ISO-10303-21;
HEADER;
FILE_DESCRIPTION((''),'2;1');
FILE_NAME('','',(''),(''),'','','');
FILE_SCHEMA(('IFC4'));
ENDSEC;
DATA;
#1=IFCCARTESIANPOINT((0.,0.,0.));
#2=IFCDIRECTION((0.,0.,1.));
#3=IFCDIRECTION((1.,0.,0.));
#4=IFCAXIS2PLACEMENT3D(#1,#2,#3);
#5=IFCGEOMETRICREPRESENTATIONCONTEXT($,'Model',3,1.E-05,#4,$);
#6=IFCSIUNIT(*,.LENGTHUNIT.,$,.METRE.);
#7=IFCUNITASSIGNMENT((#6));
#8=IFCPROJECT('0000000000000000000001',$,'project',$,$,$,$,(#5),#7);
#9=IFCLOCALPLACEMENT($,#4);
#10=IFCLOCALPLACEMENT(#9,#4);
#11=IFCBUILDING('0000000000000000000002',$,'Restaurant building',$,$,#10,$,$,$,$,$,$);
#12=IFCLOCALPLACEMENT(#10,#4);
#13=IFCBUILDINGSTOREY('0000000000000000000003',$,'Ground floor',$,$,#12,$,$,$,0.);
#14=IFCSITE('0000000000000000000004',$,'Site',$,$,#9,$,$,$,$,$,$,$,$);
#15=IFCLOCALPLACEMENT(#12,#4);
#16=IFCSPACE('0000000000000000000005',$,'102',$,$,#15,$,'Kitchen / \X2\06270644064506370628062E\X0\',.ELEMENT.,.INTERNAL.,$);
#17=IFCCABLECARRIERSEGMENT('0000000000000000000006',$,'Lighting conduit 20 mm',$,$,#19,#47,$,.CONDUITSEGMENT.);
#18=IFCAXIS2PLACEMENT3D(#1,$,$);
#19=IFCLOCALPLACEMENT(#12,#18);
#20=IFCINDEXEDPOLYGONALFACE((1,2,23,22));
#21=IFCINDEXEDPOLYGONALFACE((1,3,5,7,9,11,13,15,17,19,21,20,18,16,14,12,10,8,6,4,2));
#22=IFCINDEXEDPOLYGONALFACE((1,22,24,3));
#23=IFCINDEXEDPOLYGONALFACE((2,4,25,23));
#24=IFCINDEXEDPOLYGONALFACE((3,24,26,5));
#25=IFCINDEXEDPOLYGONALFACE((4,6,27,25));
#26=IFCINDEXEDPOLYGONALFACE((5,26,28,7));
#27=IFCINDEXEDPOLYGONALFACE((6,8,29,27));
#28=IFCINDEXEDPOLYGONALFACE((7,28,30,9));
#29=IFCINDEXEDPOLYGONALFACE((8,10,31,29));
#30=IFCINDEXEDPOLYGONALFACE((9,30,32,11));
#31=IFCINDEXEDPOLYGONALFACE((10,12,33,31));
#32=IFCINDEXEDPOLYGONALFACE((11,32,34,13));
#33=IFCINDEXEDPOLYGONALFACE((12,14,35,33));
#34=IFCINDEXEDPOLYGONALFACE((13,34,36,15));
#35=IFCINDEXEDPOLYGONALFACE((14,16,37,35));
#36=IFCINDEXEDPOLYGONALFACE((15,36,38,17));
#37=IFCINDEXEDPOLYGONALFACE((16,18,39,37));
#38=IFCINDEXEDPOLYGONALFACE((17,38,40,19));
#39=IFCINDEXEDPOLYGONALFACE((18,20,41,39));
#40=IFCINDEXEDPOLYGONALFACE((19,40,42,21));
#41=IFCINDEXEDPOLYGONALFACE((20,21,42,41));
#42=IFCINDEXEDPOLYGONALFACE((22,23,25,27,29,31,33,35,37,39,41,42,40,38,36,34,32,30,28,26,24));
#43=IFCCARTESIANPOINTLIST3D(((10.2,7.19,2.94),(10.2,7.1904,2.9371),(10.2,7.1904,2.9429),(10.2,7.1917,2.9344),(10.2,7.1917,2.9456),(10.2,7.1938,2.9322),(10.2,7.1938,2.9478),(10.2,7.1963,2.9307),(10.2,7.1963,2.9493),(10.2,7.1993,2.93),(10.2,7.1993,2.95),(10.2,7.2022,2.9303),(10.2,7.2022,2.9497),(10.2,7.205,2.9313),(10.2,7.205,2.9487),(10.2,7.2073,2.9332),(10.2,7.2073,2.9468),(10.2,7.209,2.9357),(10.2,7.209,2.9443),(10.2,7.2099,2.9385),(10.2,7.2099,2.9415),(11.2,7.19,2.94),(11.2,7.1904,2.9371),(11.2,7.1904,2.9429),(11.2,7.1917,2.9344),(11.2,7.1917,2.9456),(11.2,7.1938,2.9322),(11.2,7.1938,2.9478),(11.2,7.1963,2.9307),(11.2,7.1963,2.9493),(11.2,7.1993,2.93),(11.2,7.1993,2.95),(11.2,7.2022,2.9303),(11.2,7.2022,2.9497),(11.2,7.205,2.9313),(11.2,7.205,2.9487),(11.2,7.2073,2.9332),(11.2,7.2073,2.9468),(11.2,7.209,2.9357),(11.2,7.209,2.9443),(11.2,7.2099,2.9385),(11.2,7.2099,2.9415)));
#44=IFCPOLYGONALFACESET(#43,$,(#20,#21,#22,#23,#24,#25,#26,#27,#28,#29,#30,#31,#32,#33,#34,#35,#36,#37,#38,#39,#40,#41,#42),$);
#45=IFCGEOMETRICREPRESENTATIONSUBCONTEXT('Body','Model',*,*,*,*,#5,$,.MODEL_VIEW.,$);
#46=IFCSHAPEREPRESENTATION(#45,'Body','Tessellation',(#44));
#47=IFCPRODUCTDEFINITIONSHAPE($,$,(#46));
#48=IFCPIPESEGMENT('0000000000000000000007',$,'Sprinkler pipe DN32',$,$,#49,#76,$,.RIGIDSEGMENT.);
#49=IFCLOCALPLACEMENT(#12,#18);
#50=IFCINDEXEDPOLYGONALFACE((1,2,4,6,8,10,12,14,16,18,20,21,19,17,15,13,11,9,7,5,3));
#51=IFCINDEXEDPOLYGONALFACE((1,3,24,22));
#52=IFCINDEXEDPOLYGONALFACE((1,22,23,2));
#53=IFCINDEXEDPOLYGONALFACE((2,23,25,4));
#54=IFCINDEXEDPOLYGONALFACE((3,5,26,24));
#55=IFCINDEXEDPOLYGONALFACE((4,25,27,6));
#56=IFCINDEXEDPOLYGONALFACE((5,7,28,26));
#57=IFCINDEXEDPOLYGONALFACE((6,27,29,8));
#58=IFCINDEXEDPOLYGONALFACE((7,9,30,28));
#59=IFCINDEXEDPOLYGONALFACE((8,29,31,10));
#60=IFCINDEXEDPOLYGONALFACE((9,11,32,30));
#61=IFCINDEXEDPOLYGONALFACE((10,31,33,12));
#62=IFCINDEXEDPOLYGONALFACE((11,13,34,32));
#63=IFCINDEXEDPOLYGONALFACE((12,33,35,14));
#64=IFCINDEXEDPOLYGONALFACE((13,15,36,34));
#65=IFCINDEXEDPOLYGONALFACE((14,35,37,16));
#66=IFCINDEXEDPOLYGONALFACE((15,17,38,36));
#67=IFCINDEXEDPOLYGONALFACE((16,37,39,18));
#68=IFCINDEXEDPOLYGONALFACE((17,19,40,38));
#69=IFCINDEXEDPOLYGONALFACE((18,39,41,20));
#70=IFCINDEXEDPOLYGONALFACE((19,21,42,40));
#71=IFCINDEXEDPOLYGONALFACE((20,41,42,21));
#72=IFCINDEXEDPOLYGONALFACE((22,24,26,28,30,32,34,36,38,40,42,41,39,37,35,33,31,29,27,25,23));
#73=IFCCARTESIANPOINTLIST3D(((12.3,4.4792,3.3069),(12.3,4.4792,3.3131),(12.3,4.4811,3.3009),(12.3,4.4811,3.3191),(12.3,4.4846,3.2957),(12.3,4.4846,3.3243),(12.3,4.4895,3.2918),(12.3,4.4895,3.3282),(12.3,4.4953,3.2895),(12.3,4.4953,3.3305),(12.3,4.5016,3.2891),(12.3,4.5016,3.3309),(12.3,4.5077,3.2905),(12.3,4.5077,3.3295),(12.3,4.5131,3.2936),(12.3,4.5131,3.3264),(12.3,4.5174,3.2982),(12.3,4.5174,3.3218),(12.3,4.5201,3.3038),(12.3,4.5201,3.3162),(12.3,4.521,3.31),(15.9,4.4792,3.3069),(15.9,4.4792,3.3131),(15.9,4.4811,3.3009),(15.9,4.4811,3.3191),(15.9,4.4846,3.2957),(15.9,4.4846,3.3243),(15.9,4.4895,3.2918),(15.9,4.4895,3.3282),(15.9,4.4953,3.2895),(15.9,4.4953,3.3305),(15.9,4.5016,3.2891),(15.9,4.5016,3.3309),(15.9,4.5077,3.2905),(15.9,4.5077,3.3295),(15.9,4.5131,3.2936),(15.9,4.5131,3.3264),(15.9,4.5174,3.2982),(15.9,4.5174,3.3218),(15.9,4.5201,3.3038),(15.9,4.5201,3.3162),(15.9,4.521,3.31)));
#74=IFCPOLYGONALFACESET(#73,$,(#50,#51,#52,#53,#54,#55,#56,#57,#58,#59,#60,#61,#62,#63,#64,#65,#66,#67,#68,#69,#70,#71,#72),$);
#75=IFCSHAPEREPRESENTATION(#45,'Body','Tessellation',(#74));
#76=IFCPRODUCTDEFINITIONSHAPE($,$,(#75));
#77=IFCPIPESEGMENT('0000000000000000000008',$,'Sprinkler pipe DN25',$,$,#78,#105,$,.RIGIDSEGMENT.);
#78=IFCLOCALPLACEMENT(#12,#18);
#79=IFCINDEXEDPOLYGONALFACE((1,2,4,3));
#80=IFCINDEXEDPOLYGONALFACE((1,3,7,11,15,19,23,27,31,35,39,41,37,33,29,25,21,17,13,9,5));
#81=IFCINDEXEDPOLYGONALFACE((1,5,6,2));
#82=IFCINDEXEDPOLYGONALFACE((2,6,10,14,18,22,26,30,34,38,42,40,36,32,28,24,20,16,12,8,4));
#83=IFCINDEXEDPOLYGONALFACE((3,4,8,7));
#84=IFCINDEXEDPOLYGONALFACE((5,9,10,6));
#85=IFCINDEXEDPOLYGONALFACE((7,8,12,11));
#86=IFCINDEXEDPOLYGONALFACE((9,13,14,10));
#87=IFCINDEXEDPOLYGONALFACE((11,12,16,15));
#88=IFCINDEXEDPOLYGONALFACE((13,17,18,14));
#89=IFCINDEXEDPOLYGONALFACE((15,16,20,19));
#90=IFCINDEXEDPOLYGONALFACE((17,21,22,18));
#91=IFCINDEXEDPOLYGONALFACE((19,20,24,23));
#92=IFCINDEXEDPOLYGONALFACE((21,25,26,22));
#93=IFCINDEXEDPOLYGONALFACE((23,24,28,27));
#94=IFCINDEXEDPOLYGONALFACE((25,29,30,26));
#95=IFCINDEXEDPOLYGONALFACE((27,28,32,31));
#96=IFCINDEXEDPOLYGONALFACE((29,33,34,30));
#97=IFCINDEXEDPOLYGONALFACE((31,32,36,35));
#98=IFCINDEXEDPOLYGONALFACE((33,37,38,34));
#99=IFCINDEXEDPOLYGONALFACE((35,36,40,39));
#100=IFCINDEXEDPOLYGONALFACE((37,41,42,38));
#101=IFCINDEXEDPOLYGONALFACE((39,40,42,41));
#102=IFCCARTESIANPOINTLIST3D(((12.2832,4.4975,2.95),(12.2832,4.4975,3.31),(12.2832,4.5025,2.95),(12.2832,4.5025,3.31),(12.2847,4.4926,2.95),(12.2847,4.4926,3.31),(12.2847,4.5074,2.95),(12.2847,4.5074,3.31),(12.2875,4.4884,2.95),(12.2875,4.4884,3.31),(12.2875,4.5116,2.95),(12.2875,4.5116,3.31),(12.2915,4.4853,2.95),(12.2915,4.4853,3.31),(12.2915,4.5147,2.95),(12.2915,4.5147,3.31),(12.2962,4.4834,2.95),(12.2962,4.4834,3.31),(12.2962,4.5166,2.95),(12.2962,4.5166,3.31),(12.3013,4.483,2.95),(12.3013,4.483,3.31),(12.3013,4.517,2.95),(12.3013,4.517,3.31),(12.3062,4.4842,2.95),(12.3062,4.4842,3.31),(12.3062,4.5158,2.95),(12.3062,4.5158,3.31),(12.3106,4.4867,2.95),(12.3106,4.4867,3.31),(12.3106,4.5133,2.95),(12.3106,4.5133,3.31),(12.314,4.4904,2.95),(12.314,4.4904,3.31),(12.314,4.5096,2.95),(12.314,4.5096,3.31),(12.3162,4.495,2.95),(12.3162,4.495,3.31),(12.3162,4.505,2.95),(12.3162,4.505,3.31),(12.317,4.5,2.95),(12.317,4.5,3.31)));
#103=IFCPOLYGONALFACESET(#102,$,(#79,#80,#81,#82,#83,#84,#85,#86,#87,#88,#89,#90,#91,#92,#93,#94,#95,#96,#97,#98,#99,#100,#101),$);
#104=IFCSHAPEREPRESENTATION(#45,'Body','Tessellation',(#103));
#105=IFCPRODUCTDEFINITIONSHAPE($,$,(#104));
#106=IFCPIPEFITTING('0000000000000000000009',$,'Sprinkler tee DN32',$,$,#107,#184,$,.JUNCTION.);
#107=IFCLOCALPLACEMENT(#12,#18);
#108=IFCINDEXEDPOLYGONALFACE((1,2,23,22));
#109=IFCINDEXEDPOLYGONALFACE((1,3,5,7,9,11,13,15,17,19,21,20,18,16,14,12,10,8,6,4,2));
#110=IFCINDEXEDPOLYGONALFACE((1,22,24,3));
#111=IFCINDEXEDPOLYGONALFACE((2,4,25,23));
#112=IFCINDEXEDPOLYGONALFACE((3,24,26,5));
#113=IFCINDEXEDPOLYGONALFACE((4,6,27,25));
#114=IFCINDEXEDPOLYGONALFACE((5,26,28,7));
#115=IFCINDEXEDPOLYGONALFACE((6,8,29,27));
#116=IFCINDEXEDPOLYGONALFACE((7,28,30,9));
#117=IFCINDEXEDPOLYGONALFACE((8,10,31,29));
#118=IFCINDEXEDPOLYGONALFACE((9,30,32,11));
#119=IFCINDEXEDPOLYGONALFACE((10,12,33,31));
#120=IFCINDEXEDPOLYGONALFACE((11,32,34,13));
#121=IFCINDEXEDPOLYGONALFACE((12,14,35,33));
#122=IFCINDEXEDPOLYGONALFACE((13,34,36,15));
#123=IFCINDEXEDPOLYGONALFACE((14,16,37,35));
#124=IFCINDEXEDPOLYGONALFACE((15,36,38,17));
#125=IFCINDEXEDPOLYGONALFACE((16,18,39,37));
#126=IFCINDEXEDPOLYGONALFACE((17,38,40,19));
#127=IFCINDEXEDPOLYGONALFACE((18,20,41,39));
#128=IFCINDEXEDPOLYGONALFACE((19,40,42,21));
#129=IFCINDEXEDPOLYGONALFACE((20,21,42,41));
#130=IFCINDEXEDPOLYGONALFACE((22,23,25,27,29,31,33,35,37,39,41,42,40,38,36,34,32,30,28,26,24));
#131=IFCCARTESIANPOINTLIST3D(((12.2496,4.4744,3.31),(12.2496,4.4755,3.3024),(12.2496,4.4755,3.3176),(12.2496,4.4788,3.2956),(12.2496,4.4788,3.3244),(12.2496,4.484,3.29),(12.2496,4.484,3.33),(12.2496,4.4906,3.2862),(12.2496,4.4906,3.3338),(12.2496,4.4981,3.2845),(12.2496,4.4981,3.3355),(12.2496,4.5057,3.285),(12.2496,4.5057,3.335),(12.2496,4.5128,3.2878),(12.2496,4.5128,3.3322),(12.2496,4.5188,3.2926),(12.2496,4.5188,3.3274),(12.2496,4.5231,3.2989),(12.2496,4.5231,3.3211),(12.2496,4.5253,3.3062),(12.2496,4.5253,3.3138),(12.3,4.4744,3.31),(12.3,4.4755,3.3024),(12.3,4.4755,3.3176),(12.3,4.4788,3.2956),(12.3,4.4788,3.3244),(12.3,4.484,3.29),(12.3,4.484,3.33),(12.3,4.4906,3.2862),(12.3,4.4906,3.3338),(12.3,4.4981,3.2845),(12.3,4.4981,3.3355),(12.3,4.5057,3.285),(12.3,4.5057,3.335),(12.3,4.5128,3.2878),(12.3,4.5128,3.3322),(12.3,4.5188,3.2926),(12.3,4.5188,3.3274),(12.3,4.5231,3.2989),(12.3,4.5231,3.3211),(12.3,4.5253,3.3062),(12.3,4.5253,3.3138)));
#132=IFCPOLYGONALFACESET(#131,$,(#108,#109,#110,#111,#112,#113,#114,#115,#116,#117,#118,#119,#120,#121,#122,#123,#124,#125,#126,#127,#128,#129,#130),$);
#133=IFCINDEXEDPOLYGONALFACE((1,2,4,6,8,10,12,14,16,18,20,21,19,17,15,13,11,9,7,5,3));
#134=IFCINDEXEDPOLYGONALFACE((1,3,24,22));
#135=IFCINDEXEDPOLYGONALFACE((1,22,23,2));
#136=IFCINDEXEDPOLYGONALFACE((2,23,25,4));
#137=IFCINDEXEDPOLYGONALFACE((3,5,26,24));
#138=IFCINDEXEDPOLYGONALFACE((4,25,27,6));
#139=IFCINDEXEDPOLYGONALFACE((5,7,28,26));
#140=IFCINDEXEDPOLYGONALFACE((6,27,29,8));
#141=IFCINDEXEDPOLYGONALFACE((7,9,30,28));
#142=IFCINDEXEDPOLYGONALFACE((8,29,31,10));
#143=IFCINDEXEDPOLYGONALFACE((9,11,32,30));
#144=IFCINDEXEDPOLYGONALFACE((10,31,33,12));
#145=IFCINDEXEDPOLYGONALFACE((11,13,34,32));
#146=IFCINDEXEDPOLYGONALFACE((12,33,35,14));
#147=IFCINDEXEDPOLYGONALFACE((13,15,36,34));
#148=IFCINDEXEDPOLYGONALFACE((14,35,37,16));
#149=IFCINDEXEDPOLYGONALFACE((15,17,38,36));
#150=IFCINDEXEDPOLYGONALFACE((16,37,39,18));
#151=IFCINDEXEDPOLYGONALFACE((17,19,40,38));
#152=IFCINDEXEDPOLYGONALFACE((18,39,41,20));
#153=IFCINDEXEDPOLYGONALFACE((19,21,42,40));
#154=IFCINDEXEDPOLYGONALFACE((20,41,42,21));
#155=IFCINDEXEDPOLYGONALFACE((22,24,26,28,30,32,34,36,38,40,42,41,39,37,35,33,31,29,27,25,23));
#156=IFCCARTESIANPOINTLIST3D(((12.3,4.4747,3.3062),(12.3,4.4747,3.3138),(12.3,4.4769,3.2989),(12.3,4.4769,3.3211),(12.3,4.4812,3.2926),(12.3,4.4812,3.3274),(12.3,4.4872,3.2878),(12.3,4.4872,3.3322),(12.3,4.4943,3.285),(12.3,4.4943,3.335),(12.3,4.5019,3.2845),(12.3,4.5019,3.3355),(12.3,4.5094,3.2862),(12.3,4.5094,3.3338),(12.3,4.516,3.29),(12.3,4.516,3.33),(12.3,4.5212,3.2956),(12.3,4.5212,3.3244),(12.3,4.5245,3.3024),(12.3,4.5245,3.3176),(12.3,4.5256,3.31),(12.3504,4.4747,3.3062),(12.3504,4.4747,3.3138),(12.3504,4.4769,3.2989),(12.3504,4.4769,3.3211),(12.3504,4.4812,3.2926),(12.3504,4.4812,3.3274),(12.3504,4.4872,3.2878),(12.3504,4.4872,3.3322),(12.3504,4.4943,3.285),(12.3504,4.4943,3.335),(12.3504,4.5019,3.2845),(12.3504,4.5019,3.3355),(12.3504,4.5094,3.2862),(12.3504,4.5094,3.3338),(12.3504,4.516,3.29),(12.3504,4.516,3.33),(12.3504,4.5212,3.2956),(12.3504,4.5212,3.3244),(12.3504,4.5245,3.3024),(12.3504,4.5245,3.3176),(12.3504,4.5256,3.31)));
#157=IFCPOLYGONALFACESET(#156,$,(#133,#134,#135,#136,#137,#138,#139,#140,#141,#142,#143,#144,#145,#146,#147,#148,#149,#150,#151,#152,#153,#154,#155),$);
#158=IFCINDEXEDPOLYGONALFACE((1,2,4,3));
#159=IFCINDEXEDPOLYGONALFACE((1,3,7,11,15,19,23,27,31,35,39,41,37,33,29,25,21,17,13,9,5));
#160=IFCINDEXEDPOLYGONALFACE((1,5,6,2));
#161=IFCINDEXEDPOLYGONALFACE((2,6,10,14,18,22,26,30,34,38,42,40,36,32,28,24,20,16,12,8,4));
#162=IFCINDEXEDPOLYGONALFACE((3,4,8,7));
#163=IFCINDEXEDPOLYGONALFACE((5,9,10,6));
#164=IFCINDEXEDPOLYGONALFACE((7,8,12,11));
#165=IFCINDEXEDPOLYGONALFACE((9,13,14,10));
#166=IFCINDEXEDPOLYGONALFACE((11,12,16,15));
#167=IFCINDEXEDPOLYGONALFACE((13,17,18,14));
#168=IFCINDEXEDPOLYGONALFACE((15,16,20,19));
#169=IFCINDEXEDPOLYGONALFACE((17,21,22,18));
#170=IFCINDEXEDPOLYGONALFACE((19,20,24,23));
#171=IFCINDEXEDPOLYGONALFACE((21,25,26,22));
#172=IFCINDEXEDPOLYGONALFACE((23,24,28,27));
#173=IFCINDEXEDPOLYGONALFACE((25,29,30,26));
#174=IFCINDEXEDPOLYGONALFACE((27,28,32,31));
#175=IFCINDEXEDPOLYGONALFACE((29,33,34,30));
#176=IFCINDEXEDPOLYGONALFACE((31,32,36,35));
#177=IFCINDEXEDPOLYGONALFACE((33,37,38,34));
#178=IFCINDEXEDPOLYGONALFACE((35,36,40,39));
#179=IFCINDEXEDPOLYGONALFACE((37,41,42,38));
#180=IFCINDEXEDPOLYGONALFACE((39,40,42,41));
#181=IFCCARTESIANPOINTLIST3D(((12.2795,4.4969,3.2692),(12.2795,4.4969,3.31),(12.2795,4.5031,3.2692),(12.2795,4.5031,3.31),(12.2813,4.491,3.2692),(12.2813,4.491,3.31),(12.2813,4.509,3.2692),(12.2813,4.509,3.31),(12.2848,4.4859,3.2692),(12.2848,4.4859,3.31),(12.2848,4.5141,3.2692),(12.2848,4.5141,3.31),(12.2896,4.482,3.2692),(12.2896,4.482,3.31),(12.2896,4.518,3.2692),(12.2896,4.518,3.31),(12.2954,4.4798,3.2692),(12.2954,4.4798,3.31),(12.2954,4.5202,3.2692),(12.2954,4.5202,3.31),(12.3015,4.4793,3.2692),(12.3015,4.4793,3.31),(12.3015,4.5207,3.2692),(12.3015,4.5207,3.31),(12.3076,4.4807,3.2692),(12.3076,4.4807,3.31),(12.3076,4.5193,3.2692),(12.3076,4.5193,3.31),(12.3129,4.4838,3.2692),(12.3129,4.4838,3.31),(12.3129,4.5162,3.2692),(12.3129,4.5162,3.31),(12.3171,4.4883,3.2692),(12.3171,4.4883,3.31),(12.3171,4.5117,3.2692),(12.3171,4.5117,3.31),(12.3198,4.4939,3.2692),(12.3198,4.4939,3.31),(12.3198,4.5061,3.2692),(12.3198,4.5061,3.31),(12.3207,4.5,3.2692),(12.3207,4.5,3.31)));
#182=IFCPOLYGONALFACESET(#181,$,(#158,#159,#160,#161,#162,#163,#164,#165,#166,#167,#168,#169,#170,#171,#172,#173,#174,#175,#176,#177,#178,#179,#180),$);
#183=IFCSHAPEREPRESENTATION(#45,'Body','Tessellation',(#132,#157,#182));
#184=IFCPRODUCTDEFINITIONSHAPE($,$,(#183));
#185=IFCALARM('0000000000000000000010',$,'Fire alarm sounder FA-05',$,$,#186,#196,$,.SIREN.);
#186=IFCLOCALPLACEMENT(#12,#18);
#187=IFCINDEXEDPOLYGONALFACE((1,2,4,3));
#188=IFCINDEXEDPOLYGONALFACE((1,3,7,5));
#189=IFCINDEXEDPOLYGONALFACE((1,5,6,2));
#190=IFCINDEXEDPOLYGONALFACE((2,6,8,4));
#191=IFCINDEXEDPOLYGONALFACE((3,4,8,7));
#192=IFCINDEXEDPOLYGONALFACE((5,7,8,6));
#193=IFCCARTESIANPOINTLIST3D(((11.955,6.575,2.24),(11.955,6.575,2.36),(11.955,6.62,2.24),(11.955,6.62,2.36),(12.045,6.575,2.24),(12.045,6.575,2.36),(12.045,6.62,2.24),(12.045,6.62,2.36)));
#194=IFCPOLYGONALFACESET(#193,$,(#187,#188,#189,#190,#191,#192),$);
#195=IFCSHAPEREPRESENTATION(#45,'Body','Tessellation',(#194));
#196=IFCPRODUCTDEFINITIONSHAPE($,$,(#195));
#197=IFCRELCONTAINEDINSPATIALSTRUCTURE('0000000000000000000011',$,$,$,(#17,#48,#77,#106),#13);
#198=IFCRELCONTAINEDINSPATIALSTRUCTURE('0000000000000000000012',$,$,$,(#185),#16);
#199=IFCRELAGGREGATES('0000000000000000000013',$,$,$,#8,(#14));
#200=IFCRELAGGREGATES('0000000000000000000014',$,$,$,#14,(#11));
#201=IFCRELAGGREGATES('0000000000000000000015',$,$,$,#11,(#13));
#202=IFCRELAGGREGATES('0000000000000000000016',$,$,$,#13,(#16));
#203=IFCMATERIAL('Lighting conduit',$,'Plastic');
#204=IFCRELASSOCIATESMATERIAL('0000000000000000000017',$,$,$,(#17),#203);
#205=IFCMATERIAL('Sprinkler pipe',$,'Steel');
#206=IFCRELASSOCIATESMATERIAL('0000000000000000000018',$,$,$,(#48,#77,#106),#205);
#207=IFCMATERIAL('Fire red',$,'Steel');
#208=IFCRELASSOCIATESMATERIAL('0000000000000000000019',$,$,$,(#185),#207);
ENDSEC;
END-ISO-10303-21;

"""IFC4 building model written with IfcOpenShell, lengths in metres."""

from ifc_helpers import new_model, si_unit, frame, origin_with_axes, origin_2d, place, context, subcontext, project, spatial, rectangle, circle, extrude, material, element, save


model = new_model("IFC4")

# Units and contexts
model_context = context("Model", 3, precision=1e-05, world=origin_with_axes())
body_context = subcontext(model_context, "Body", "Model", "MODEL_VIEW")
ifc_project = project(units=[si_unit("LENGTHUNIT", "METRE")], contexts=[model_context])

# Site, building, storey
site_placement = place(None, origin_with_axes())
site = spatial("IfcSite", under=ifc_project, at=site_placement, Name="Site")
building_placement = place(site_placement, origin_with_axes())
building = spatial("IfcBuilding", under=site, at=building_placement, Name="Restaurant building")
storey_placement = place(building_placement, origin_with_axes())
storey = spatial("IfcBuildingStorey", under=building, at=storey_placement, Name="Ground floor", Elevation=0.0)

# Shared definitions
space_1_placement = place(storey_placement, origin_with_axes())
space_1 = spatial("IfcSpace", under=storey, at=space_1_placement, Name="102", LongName="Kitchen / المطبخ", CompositionType="ELEMENT", PredefinedType="INTERNAL")

# Shared definitions
ifc_material_1 = material(Name="Fire red", Category="Steel")

# Cable carrier segment
ifc_material_2 = material(Name="Lighting conduit", Category="Plastic")
cable_carrier_segment_1_placement = place(storey_placement, frame((11.2, 7.2, 2.94)))
element("IfcCableCarrierSegment", 1, at=cable_carrier_segment_1_placement, inside=storey, material=ifc_material_2, Name="Lighting conduit 20 mm", PredefinedType="CONDUITSEGMENT", context=body_context, shape_type="SweptSolid", body=[
    extrude(circle(Radius=0.01, at=origin_2d()), frame((0.0, 0.0, 0.0), z_axis=(-1.0, 0.0, 0.0), x_axis=(0.0, -1.0, 0.0)), (0.0, 0.0, 1.0), 1.0),
])

# Pipe segments
ifc_material_3 = material(Name="Sprinkler pipe", Category="Steel")
pipe_segment_1_placement = place(storey_placement, frame((12.3, 4.5, 3.31)))
element("IfcPipeSegment", 2, at=pipe_segment_1_placement, inside=storey, material=ifc_material_3, Name="Sprinkler pipe DN32", PredefinedType="RIGIDSEGMENT", context=body_context, shape_type="SweptSolid", body=[
    extrude(circle(Radius=0.021, at=origin_2d()), frame((0.0, 0.0, 0.0), z_axis=(1.0, 0.0, 0.0), x_axis=(0.0, 1.0, 0.0)), (0.0, 0.0, 1.0), 3.6),
])
pipe_segment_2_placement = place(storey_placement, frame((12.3, 4.5, 3.31)))
element("IfcPipeSegment", 3, at=pipe_segment_2_placement, inside=storey, material=ifc_material_3, Name="Sprinkler pipe DN25", PredefinedType="RIGIDSEGMENT", context=body_context, shape_type="SweptSolid", body=[
    extrude(circle(Radius=0.017, at=origin_2d()), frame((0.0, 0.0, 0.0), z_axis=(0.0, 0.0, -1.0), x_axis=(1.0, 0.0, 0.0)), (0.0, 0.0, 1.0), 0.36),
])

# Pipe fitting
pipe_fitting_placement = place(storey_placement, frame((12.3, 4.5, 3.31)))
element("IfcPipeFitting", 4, at=pipe_fitting_placement, inside=storey, material=ifc_material_3, Name="Sprinkler tee DN32", PredefinedType="JUNCTION", context=body_context, shape_type="SweptSolid", body=[
    extrude(circle(Radius=0.0256, at=origin_2d()), frame((0.0, 0.0, 0.0), z_axis=(-1.0, 0.0, 0.0), x_axis=(0.0, -1.0, 0.0)), (0.0, 0.0, 1.0), 0.0504),
    extrude(circle(Radius=0.0256, at=origin_2d()), frame((0.0, 0.0, 0.0), z_axis=(1.0, 0.0, 0.0), x_axis=(0.0, 1.0, 0.0)), (0.0, 0.0, 1.0), 0.0504),
    extrude(circle(Radius=0.0207, at=origin_2d()), frame((0.0, 0.0, 0.0), z_axis=(0.0, 0.0, -1.0), x_axis=(1.0, 0.0, 0.0)), (0.0, 0.0, 1.0), 0.0408),
])

# Alarm
alarm_placement = place(storey_placement, frame((12.0, 6.575, 2.3)))
element("IfcAlarm", 5, at=alarm_placement, inside=space_1, material=ifc_material_1, Name="Fire alarm sounder FA-05", PredefinedType="SIREN", context=body_context, shape_type="SweptSolid", body=[
    extrude(rectangle(XDim=0.09, YDim=0.045, at=origin_2d()), frame((0.0, 0.0225, -0.06)), (0.0, 0.0, 1.0), 0.12),
])

save(model, "model.ifc")
